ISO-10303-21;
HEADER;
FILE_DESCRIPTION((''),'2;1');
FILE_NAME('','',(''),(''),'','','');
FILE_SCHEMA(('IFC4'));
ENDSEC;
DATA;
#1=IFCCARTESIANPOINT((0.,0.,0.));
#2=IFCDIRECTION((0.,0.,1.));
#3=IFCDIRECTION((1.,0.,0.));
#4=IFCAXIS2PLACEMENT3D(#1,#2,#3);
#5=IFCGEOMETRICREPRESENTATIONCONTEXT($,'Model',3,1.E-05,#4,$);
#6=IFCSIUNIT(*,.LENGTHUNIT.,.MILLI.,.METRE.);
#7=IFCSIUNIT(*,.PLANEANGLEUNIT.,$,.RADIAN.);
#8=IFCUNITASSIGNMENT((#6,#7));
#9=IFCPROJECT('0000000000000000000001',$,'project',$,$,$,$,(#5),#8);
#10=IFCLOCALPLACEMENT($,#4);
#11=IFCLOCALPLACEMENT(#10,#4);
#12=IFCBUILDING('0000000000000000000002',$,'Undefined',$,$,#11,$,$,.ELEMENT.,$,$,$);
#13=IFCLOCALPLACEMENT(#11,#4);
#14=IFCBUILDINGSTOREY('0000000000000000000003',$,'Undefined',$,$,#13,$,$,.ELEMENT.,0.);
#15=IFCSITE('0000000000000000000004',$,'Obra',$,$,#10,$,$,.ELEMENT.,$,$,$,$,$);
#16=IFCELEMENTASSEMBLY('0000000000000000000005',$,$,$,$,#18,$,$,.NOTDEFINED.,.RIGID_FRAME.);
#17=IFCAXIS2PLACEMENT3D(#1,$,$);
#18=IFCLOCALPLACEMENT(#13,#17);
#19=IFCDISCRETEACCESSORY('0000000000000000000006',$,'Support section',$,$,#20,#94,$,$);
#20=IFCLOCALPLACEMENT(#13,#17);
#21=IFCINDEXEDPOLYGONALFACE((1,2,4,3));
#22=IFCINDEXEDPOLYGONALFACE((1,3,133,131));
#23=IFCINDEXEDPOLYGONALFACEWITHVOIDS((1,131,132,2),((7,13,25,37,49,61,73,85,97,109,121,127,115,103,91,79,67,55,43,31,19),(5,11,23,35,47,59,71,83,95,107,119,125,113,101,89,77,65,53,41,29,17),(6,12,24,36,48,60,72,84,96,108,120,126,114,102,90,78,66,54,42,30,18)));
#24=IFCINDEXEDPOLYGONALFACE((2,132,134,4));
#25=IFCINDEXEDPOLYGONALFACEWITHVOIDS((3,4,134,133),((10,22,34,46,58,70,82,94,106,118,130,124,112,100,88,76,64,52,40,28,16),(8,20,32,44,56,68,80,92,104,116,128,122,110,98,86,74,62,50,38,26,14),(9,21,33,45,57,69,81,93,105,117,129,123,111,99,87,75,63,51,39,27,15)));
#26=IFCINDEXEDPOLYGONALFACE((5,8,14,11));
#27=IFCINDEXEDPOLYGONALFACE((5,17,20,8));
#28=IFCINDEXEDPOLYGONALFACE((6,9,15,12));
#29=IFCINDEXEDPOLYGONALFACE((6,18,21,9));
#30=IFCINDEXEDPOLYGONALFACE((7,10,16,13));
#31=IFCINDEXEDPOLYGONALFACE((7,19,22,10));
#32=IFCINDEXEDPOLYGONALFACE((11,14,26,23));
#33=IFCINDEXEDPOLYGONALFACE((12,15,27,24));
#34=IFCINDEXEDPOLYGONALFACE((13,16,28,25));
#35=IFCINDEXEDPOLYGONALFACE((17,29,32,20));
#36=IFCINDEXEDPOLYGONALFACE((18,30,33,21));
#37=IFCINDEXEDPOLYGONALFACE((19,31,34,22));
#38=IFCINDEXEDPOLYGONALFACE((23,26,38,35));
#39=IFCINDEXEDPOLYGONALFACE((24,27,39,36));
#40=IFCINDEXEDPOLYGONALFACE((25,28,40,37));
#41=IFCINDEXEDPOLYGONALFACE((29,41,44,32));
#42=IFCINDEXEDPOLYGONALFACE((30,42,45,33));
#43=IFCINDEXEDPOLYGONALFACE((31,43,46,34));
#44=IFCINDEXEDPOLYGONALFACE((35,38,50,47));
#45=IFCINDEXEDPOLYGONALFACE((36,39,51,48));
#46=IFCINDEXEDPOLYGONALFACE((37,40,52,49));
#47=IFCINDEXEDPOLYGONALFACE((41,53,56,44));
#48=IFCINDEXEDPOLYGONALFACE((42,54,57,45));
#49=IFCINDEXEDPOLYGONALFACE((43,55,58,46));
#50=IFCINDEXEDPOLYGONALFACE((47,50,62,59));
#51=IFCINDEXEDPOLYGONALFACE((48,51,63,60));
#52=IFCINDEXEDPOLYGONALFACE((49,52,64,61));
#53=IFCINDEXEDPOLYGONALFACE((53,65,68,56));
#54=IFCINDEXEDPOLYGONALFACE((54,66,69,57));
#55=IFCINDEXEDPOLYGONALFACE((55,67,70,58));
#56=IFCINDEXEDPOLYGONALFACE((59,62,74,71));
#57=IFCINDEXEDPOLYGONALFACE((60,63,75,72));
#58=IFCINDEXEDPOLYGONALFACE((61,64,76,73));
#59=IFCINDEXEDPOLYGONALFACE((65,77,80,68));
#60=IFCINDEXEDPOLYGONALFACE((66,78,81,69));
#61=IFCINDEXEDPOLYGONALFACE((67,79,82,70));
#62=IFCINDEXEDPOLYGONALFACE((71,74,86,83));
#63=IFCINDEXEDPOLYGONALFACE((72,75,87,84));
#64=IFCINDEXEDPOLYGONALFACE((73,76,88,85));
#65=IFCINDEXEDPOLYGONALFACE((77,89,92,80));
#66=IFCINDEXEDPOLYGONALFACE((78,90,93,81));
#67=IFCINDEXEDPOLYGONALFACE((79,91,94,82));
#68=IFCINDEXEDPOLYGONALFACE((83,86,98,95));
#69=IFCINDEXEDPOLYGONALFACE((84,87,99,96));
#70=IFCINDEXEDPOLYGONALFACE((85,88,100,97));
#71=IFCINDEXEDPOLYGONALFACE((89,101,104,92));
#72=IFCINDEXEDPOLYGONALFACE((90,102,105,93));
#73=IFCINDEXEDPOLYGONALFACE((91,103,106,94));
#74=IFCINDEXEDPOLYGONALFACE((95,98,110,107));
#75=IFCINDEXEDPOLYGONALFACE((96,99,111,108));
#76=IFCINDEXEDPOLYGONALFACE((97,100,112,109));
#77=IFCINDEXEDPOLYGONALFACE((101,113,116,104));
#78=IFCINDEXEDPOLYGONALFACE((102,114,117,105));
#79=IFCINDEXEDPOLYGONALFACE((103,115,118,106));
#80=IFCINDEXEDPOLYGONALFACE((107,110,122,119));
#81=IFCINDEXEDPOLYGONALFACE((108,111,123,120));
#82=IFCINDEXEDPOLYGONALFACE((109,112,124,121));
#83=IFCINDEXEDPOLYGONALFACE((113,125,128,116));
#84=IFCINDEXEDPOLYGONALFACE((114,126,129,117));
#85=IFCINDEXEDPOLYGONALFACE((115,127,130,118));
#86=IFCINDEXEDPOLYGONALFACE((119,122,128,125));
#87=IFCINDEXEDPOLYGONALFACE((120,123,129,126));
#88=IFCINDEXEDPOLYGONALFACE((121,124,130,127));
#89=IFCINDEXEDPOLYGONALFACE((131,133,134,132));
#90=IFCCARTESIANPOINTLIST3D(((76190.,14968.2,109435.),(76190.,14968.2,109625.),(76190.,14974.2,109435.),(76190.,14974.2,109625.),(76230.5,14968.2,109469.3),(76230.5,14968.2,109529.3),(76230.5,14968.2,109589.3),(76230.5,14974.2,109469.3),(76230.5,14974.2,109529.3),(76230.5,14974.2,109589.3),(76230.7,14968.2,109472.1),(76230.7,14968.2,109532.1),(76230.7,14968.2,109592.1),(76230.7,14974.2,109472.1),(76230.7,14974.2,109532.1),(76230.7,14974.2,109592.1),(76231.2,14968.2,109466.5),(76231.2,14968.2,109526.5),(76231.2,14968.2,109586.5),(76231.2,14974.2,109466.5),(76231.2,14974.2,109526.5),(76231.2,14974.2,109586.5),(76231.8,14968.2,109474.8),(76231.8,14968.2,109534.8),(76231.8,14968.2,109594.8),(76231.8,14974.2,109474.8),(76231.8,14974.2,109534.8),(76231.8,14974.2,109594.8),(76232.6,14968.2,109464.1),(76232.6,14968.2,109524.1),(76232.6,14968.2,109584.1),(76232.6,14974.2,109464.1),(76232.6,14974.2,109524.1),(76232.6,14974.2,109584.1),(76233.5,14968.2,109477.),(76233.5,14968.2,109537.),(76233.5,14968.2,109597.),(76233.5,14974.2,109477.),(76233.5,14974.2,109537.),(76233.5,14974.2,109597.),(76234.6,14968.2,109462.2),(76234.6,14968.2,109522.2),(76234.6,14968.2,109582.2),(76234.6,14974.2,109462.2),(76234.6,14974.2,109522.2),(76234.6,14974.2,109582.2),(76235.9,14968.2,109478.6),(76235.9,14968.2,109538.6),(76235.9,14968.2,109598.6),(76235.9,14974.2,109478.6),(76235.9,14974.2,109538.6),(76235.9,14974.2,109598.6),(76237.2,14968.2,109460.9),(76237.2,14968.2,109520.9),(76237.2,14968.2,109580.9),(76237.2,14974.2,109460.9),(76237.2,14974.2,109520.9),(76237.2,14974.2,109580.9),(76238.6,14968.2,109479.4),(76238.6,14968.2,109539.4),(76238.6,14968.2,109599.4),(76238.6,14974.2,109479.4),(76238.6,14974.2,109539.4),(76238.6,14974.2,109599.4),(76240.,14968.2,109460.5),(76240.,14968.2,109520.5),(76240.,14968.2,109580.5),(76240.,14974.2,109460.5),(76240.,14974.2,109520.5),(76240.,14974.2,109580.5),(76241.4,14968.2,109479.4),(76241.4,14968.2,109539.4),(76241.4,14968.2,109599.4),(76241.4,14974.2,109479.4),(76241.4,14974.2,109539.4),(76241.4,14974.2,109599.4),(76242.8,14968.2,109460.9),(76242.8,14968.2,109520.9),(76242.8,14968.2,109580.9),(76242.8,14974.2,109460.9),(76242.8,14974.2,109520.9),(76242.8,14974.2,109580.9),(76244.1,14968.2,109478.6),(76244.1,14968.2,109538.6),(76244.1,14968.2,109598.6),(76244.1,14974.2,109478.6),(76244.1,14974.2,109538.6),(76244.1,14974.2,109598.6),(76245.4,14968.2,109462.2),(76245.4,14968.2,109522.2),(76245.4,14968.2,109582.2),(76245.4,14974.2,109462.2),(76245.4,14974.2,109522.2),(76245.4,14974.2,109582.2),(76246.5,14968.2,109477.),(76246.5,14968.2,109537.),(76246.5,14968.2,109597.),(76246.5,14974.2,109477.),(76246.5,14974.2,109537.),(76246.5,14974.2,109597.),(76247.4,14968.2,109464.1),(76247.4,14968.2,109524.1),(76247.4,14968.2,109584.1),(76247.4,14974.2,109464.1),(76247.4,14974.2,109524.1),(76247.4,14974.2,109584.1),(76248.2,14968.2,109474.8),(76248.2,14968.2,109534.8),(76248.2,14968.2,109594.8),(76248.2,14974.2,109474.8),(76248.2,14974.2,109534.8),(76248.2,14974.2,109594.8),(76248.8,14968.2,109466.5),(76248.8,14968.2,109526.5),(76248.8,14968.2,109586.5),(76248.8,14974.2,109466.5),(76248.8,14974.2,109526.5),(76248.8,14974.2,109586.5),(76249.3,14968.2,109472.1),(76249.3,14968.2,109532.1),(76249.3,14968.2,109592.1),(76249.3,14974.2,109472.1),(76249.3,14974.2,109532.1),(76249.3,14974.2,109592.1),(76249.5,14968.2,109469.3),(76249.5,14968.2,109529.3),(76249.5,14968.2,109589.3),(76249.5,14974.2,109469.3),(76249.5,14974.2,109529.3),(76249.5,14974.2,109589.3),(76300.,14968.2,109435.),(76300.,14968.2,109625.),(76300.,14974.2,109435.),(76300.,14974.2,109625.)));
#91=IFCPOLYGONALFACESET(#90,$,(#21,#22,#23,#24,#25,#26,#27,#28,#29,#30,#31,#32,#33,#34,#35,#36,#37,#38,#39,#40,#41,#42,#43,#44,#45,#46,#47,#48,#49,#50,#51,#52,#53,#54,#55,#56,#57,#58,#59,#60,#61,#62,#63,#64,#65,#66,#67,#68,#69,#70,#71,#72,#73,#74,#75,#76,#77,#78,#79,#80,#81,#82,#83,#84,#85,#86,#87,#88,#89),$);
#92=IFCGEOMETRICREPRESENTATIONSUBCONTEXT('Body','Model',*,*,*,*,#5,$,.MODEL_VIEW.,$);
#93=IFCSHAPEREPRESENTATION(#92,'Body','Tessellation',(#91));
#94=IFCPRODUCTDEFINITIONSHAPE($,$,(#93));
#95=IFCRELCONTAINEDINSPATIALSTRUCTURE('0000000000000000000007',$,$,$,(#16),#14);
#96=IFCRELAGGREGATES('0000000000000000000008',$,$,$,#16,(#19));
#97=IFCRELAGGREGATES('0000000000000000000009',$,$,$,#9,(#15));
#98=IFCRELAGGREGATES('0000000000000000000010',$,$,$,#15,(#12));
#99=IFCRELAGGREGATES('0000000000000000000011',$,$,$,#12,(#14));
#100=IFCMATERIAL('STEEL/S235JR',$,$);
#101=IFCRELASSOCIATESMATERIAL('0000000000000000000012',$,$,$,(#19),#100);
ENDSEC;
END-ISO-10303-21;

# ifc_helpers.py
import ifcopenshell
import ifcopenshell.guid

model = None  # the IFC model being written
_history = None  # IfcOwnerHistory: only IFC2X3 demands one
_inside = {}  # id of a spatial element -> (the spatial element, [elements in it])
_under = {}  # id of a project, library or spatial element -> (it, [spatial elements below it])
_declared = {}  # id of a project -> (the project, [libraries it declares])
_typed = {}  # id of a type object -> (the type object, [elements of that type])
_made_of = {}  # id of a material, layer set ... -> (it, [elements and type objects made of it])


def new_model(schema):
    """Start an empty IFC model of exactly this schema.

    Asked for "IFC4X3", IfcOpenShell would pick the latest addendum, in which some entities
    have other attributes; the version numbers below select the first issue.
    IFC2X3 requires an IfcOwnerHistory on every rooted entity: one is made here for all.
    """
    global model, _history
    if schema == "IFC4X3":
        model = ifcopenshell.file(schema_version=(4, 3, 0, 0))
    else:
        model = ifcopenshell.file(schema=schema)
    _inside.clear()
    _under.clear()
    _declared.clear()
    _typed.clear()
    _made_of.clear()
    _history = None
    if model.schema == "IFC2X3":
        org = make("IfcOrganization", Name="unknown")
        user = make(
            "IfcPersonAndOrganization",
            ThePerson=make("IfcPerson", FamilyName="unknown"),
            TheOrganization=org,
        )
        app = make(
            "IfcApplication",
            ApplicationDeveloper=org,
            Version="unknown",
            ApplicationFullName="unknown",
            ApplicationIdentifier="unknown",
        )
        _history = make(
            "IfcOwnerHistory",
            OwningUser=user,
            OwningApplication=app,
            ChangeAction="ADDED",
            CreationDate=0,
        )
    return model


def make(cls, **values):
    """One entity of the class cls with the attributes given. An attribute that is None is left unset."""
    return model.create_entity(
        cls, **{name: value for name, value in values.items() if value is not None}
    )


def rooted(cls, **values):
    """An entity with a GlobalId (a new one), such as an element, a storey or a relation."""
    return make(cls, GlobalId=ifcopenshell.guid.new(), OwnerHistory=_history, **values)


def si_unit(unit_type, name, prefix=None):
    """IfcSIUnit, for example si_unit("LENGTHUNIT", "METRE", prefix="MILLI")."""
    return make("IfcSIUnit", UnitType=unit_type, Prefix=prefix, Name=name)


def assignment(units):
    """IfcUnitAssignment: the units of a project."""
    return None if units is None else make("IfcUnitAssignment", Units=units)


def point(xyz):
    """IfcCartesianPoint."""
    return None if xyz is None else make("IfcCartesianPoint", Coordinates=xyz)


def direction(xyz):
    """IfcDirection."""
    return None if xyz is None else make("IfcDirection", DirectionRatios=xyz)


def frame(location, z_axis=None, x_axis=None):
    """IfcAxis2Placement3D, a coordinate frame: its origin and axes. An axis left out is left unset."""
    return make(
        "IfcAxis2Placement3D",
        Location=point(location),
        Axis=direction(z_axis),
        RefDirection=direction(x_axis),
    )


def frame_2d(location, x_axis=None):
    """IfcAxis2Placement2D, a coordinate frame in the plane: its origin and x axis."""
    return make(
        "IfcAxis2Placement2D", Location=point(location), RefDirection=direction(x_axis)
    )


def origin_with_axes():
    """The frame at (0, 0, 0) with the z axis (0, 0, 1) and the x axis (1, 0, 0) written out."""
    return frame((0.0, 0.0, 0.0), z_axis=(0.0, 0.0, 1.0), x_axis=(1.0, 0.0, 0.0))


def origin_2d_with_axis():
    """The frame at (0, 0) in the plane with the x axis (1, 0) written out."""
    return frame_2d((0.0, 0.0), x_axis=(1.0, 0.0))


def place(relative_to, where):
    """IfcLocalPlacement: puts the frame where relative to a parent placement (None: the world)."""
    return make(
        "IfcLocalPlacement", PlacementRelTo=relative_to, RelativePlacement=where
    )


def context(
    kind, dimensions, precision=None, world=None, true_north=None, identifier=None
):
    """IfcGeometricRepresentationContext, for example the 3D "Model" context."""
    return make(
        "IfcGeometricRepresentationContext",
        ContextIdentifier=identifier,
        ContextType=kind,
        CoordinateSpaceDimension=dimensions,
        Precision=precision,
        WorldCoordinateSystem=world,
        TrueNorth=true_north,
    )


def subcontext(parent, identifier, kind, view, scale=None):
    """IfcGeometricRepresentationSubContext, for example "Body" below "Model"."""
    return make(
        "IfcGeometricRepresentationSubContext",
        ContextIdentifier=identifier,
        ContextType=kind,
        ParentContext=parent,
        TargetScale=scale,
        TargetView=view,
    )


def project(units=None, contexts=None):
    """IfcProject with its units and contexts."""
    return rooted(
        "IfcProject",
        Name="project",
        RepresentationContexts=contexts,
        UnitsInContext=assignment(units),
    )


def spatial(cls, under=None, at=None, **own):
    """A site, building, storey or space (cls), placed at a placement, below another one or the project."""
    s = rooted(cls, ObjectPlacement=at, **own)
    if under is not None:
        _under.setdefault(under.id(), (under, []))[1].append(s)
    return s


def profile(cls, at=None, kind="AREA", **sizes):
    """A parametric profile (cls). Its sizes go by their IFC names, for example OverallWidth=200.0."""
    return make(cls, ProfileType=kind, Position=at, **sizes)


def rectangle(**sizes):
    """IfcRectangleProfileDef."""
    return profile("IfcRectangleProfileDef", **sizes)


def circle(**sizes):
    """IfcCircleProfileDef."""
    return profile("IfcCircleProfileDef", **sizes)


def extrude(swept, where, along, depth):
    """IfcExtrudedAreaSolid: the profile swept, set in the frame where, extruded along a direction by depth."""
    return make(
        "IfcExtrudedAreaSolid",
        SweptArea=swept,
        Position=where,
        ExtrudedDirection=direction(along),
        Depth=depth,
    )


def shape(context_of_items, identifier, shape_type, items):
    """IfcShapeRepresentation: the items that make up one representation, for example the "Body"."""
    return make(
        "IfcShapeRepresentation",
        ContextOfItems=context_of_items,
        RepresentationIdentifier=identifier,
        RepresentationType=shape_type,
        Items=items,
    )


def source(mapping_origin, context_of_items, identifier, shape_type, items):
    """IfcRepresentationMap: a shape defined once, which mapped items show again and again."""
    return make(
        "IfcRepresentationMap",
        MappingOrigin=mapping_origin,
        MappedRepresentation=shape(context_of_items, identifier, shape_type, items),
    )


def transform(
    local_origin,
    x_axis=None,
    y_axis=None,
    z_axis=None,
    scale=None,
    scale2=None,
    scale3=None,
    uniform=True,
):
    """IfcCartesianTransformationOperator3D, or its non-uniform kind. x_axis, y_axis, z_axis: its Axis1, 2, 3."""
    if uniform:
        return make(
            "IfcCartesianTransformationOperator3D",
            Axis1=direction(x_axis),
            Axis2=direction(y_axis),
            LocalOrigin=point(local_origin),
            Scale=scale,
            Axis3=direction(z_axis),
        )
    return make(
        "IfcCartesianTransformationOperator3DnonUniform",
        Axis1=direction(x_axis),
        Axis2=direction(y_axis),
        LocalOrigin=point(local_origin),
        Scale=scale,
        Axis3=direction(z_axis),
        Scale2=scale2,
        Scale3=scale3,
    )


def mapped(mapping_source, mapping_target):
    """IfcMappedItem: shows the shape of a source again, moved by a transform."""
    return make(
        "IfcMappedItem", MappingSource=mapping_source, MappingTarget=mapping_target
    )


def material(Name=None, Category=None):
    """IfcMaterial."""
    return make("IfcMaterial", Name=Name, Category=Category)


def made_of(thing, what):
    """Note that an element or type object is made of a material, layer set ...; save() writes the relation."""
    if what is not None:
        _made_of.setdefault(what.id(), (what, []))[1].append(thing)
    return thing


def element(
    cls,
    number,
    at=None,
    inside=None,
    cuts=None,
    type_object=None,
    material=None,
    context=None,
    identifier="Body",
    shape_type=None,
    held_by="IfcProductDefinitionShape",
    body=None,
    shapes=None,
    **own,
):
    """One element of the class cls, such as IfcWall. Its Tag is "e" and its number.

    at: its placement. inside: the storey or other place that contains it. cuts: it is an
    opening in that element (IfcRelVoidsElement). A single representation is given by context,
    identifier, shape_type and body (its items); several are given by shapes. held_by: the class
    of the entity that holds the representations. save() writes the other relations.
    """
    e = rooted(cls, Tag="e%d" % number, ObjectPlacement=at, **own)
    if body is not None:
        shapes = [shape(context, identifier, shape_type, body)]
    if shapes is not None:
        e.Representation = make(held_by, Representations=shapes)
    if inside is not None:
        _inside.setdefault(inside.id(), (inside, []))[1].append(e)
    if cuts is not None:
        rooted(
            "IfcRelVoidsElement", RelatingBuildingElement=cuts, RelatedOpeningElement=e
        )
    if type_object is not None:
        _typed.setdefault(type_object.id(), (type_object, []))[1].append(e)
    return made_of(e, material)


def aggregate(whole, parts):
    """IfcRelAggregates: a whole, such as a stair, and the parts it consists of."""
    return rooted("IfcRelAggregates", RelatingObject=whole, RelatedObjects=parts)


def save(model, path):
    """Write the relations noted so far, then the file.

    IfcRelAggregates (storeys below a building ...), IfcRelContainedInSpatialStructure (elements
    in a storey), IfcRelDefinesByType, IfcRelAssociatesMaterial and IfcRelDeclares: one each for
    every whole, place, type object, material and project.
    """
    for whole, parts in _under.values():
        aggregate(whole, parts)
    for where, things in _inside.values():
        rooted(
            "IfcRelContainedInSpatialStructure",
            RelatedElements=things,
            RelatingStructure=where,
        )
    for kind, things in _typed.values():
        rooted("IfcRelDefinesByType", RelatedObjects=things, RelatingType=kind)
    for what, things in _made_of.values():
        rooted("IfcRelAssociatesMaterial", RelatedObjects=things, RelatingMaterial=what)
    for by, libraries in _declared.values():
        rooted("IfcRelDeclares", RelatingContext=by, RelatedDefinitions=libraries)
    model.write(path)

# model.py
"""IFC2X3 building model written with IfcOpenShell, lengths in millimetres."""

from ifc_helpers import new_model, si_unit, frame, origin_with_axes, origin_2d_with_axis, place, context, subcontext, project, spatial, rectangle, circle, extrude, source, transform, mapped, material, element, aggregate, save


model = new_model("IFC2X3")

# Units and contexts
model_context = context("Model", 3, precision=1e-05, world=origin_with_axes())
body_context = subcontext(model_context, "Body", "Model", "MODEL_VIEW")
ifc_project = project(units=[si_unit("LENGTHUNIT", "METRE", prefix="MILLI"), si_unit("PLANEANGLEUNIT", "RADIAN")], contexts=[model_context])

# Site, building, storey
site_placement = place(None, origin_with_axes())
site = spatial("IfcSite", under=ifc_project, at=site_placement, Name="Obra", CompositionType="ELEMENT")
building_placement = place(site_placement, origin_with_axes())
building = spatial("IfcBuilding", under=site, at=building_placement, Name="Undefined", CompositionType="ELEMENT")
storey_placement = place(building_placement, origin_with_axes())
storey = spatial("IfcBuildingStorey", under=building, at=storey_placement, Name="Undefined", CompositionType="ELEMENT", Elevation=0.0)

# Shared definitions
ifc_material_1 = material(Name="STEEL/S235JR")

# Element assembly, discrete accessory, opening
shared_shape_1 = source(origin_with_axes(), body_context, "Body", "SweptSolid", [
    extrude(circle(Radius=9.5, at=origin_2d_with_axis()), frame((0.0, -9.2, 0.0), z_axis=(0.0, 1.0, 0.0), x_axis=(1.0, 0.0, 0.0)), (0.0, 0.0, 1.0), 6.2),
])
assembly_1_placement = place(storey_placement, origin_with_axes())
assembly_1 = element("IfcElementAssembly", 1, at=assembly_1_placement, inside=storey, AssemblyPlace="NOTDEFINED", PredefinedType="RIGID_FRAME")
discrete_accessory_1_placement = place(assembly_1_placement, frame((76245.0, 14971.2, 109435.0), z_axis=(0.0, 0.0, 1.0), x_axis=(1.0, 0.0, 0.0)))
discrete_accessory_1 = element("IfcDiscreteAccessory", 2, at=discrete_accessory_1_placement, material=ifc_material_1, Name="Support section", context=body_context, shape_type="SweptSolid", body=[
    extrude(rectangle(XDim=6.0, YDim=110.0, at=origin_2d_with_axis()), frame((0.0, 0.0, 190.0), z_axis=(0.0, 0.0, -1.0), x_axis=(0.0, 1.0, 0.0)), (0.0, 0.0, 1.0), 190.0),
])
opening_1_placement = place(assembly_1_placement, frame((76290.0, 14965.1, 109650.0), z_axis=(-1.0, 0.0, 0.0), x_axis=(0.0, 0.0, -1.0)))
element("IfcOpeningElement", 3, at=opening_1_placement, cuts=discrete_accessory_1, ObjectType="Opening", context=body_context, shape_type="MappedRepresentation", body=[
    mapped(shared_shape_1, transform((60.0, 0.0, 50.0))),
    mapped(shared_shape_1, transform((120.0, 0.0, 50.0))),
    mapped(shared_shape_1, transform((180.0, 0.0, 50.0))),
])
aggregate(assembly_1, [discrete_accessory_1])

save(model, "model.ifc")
